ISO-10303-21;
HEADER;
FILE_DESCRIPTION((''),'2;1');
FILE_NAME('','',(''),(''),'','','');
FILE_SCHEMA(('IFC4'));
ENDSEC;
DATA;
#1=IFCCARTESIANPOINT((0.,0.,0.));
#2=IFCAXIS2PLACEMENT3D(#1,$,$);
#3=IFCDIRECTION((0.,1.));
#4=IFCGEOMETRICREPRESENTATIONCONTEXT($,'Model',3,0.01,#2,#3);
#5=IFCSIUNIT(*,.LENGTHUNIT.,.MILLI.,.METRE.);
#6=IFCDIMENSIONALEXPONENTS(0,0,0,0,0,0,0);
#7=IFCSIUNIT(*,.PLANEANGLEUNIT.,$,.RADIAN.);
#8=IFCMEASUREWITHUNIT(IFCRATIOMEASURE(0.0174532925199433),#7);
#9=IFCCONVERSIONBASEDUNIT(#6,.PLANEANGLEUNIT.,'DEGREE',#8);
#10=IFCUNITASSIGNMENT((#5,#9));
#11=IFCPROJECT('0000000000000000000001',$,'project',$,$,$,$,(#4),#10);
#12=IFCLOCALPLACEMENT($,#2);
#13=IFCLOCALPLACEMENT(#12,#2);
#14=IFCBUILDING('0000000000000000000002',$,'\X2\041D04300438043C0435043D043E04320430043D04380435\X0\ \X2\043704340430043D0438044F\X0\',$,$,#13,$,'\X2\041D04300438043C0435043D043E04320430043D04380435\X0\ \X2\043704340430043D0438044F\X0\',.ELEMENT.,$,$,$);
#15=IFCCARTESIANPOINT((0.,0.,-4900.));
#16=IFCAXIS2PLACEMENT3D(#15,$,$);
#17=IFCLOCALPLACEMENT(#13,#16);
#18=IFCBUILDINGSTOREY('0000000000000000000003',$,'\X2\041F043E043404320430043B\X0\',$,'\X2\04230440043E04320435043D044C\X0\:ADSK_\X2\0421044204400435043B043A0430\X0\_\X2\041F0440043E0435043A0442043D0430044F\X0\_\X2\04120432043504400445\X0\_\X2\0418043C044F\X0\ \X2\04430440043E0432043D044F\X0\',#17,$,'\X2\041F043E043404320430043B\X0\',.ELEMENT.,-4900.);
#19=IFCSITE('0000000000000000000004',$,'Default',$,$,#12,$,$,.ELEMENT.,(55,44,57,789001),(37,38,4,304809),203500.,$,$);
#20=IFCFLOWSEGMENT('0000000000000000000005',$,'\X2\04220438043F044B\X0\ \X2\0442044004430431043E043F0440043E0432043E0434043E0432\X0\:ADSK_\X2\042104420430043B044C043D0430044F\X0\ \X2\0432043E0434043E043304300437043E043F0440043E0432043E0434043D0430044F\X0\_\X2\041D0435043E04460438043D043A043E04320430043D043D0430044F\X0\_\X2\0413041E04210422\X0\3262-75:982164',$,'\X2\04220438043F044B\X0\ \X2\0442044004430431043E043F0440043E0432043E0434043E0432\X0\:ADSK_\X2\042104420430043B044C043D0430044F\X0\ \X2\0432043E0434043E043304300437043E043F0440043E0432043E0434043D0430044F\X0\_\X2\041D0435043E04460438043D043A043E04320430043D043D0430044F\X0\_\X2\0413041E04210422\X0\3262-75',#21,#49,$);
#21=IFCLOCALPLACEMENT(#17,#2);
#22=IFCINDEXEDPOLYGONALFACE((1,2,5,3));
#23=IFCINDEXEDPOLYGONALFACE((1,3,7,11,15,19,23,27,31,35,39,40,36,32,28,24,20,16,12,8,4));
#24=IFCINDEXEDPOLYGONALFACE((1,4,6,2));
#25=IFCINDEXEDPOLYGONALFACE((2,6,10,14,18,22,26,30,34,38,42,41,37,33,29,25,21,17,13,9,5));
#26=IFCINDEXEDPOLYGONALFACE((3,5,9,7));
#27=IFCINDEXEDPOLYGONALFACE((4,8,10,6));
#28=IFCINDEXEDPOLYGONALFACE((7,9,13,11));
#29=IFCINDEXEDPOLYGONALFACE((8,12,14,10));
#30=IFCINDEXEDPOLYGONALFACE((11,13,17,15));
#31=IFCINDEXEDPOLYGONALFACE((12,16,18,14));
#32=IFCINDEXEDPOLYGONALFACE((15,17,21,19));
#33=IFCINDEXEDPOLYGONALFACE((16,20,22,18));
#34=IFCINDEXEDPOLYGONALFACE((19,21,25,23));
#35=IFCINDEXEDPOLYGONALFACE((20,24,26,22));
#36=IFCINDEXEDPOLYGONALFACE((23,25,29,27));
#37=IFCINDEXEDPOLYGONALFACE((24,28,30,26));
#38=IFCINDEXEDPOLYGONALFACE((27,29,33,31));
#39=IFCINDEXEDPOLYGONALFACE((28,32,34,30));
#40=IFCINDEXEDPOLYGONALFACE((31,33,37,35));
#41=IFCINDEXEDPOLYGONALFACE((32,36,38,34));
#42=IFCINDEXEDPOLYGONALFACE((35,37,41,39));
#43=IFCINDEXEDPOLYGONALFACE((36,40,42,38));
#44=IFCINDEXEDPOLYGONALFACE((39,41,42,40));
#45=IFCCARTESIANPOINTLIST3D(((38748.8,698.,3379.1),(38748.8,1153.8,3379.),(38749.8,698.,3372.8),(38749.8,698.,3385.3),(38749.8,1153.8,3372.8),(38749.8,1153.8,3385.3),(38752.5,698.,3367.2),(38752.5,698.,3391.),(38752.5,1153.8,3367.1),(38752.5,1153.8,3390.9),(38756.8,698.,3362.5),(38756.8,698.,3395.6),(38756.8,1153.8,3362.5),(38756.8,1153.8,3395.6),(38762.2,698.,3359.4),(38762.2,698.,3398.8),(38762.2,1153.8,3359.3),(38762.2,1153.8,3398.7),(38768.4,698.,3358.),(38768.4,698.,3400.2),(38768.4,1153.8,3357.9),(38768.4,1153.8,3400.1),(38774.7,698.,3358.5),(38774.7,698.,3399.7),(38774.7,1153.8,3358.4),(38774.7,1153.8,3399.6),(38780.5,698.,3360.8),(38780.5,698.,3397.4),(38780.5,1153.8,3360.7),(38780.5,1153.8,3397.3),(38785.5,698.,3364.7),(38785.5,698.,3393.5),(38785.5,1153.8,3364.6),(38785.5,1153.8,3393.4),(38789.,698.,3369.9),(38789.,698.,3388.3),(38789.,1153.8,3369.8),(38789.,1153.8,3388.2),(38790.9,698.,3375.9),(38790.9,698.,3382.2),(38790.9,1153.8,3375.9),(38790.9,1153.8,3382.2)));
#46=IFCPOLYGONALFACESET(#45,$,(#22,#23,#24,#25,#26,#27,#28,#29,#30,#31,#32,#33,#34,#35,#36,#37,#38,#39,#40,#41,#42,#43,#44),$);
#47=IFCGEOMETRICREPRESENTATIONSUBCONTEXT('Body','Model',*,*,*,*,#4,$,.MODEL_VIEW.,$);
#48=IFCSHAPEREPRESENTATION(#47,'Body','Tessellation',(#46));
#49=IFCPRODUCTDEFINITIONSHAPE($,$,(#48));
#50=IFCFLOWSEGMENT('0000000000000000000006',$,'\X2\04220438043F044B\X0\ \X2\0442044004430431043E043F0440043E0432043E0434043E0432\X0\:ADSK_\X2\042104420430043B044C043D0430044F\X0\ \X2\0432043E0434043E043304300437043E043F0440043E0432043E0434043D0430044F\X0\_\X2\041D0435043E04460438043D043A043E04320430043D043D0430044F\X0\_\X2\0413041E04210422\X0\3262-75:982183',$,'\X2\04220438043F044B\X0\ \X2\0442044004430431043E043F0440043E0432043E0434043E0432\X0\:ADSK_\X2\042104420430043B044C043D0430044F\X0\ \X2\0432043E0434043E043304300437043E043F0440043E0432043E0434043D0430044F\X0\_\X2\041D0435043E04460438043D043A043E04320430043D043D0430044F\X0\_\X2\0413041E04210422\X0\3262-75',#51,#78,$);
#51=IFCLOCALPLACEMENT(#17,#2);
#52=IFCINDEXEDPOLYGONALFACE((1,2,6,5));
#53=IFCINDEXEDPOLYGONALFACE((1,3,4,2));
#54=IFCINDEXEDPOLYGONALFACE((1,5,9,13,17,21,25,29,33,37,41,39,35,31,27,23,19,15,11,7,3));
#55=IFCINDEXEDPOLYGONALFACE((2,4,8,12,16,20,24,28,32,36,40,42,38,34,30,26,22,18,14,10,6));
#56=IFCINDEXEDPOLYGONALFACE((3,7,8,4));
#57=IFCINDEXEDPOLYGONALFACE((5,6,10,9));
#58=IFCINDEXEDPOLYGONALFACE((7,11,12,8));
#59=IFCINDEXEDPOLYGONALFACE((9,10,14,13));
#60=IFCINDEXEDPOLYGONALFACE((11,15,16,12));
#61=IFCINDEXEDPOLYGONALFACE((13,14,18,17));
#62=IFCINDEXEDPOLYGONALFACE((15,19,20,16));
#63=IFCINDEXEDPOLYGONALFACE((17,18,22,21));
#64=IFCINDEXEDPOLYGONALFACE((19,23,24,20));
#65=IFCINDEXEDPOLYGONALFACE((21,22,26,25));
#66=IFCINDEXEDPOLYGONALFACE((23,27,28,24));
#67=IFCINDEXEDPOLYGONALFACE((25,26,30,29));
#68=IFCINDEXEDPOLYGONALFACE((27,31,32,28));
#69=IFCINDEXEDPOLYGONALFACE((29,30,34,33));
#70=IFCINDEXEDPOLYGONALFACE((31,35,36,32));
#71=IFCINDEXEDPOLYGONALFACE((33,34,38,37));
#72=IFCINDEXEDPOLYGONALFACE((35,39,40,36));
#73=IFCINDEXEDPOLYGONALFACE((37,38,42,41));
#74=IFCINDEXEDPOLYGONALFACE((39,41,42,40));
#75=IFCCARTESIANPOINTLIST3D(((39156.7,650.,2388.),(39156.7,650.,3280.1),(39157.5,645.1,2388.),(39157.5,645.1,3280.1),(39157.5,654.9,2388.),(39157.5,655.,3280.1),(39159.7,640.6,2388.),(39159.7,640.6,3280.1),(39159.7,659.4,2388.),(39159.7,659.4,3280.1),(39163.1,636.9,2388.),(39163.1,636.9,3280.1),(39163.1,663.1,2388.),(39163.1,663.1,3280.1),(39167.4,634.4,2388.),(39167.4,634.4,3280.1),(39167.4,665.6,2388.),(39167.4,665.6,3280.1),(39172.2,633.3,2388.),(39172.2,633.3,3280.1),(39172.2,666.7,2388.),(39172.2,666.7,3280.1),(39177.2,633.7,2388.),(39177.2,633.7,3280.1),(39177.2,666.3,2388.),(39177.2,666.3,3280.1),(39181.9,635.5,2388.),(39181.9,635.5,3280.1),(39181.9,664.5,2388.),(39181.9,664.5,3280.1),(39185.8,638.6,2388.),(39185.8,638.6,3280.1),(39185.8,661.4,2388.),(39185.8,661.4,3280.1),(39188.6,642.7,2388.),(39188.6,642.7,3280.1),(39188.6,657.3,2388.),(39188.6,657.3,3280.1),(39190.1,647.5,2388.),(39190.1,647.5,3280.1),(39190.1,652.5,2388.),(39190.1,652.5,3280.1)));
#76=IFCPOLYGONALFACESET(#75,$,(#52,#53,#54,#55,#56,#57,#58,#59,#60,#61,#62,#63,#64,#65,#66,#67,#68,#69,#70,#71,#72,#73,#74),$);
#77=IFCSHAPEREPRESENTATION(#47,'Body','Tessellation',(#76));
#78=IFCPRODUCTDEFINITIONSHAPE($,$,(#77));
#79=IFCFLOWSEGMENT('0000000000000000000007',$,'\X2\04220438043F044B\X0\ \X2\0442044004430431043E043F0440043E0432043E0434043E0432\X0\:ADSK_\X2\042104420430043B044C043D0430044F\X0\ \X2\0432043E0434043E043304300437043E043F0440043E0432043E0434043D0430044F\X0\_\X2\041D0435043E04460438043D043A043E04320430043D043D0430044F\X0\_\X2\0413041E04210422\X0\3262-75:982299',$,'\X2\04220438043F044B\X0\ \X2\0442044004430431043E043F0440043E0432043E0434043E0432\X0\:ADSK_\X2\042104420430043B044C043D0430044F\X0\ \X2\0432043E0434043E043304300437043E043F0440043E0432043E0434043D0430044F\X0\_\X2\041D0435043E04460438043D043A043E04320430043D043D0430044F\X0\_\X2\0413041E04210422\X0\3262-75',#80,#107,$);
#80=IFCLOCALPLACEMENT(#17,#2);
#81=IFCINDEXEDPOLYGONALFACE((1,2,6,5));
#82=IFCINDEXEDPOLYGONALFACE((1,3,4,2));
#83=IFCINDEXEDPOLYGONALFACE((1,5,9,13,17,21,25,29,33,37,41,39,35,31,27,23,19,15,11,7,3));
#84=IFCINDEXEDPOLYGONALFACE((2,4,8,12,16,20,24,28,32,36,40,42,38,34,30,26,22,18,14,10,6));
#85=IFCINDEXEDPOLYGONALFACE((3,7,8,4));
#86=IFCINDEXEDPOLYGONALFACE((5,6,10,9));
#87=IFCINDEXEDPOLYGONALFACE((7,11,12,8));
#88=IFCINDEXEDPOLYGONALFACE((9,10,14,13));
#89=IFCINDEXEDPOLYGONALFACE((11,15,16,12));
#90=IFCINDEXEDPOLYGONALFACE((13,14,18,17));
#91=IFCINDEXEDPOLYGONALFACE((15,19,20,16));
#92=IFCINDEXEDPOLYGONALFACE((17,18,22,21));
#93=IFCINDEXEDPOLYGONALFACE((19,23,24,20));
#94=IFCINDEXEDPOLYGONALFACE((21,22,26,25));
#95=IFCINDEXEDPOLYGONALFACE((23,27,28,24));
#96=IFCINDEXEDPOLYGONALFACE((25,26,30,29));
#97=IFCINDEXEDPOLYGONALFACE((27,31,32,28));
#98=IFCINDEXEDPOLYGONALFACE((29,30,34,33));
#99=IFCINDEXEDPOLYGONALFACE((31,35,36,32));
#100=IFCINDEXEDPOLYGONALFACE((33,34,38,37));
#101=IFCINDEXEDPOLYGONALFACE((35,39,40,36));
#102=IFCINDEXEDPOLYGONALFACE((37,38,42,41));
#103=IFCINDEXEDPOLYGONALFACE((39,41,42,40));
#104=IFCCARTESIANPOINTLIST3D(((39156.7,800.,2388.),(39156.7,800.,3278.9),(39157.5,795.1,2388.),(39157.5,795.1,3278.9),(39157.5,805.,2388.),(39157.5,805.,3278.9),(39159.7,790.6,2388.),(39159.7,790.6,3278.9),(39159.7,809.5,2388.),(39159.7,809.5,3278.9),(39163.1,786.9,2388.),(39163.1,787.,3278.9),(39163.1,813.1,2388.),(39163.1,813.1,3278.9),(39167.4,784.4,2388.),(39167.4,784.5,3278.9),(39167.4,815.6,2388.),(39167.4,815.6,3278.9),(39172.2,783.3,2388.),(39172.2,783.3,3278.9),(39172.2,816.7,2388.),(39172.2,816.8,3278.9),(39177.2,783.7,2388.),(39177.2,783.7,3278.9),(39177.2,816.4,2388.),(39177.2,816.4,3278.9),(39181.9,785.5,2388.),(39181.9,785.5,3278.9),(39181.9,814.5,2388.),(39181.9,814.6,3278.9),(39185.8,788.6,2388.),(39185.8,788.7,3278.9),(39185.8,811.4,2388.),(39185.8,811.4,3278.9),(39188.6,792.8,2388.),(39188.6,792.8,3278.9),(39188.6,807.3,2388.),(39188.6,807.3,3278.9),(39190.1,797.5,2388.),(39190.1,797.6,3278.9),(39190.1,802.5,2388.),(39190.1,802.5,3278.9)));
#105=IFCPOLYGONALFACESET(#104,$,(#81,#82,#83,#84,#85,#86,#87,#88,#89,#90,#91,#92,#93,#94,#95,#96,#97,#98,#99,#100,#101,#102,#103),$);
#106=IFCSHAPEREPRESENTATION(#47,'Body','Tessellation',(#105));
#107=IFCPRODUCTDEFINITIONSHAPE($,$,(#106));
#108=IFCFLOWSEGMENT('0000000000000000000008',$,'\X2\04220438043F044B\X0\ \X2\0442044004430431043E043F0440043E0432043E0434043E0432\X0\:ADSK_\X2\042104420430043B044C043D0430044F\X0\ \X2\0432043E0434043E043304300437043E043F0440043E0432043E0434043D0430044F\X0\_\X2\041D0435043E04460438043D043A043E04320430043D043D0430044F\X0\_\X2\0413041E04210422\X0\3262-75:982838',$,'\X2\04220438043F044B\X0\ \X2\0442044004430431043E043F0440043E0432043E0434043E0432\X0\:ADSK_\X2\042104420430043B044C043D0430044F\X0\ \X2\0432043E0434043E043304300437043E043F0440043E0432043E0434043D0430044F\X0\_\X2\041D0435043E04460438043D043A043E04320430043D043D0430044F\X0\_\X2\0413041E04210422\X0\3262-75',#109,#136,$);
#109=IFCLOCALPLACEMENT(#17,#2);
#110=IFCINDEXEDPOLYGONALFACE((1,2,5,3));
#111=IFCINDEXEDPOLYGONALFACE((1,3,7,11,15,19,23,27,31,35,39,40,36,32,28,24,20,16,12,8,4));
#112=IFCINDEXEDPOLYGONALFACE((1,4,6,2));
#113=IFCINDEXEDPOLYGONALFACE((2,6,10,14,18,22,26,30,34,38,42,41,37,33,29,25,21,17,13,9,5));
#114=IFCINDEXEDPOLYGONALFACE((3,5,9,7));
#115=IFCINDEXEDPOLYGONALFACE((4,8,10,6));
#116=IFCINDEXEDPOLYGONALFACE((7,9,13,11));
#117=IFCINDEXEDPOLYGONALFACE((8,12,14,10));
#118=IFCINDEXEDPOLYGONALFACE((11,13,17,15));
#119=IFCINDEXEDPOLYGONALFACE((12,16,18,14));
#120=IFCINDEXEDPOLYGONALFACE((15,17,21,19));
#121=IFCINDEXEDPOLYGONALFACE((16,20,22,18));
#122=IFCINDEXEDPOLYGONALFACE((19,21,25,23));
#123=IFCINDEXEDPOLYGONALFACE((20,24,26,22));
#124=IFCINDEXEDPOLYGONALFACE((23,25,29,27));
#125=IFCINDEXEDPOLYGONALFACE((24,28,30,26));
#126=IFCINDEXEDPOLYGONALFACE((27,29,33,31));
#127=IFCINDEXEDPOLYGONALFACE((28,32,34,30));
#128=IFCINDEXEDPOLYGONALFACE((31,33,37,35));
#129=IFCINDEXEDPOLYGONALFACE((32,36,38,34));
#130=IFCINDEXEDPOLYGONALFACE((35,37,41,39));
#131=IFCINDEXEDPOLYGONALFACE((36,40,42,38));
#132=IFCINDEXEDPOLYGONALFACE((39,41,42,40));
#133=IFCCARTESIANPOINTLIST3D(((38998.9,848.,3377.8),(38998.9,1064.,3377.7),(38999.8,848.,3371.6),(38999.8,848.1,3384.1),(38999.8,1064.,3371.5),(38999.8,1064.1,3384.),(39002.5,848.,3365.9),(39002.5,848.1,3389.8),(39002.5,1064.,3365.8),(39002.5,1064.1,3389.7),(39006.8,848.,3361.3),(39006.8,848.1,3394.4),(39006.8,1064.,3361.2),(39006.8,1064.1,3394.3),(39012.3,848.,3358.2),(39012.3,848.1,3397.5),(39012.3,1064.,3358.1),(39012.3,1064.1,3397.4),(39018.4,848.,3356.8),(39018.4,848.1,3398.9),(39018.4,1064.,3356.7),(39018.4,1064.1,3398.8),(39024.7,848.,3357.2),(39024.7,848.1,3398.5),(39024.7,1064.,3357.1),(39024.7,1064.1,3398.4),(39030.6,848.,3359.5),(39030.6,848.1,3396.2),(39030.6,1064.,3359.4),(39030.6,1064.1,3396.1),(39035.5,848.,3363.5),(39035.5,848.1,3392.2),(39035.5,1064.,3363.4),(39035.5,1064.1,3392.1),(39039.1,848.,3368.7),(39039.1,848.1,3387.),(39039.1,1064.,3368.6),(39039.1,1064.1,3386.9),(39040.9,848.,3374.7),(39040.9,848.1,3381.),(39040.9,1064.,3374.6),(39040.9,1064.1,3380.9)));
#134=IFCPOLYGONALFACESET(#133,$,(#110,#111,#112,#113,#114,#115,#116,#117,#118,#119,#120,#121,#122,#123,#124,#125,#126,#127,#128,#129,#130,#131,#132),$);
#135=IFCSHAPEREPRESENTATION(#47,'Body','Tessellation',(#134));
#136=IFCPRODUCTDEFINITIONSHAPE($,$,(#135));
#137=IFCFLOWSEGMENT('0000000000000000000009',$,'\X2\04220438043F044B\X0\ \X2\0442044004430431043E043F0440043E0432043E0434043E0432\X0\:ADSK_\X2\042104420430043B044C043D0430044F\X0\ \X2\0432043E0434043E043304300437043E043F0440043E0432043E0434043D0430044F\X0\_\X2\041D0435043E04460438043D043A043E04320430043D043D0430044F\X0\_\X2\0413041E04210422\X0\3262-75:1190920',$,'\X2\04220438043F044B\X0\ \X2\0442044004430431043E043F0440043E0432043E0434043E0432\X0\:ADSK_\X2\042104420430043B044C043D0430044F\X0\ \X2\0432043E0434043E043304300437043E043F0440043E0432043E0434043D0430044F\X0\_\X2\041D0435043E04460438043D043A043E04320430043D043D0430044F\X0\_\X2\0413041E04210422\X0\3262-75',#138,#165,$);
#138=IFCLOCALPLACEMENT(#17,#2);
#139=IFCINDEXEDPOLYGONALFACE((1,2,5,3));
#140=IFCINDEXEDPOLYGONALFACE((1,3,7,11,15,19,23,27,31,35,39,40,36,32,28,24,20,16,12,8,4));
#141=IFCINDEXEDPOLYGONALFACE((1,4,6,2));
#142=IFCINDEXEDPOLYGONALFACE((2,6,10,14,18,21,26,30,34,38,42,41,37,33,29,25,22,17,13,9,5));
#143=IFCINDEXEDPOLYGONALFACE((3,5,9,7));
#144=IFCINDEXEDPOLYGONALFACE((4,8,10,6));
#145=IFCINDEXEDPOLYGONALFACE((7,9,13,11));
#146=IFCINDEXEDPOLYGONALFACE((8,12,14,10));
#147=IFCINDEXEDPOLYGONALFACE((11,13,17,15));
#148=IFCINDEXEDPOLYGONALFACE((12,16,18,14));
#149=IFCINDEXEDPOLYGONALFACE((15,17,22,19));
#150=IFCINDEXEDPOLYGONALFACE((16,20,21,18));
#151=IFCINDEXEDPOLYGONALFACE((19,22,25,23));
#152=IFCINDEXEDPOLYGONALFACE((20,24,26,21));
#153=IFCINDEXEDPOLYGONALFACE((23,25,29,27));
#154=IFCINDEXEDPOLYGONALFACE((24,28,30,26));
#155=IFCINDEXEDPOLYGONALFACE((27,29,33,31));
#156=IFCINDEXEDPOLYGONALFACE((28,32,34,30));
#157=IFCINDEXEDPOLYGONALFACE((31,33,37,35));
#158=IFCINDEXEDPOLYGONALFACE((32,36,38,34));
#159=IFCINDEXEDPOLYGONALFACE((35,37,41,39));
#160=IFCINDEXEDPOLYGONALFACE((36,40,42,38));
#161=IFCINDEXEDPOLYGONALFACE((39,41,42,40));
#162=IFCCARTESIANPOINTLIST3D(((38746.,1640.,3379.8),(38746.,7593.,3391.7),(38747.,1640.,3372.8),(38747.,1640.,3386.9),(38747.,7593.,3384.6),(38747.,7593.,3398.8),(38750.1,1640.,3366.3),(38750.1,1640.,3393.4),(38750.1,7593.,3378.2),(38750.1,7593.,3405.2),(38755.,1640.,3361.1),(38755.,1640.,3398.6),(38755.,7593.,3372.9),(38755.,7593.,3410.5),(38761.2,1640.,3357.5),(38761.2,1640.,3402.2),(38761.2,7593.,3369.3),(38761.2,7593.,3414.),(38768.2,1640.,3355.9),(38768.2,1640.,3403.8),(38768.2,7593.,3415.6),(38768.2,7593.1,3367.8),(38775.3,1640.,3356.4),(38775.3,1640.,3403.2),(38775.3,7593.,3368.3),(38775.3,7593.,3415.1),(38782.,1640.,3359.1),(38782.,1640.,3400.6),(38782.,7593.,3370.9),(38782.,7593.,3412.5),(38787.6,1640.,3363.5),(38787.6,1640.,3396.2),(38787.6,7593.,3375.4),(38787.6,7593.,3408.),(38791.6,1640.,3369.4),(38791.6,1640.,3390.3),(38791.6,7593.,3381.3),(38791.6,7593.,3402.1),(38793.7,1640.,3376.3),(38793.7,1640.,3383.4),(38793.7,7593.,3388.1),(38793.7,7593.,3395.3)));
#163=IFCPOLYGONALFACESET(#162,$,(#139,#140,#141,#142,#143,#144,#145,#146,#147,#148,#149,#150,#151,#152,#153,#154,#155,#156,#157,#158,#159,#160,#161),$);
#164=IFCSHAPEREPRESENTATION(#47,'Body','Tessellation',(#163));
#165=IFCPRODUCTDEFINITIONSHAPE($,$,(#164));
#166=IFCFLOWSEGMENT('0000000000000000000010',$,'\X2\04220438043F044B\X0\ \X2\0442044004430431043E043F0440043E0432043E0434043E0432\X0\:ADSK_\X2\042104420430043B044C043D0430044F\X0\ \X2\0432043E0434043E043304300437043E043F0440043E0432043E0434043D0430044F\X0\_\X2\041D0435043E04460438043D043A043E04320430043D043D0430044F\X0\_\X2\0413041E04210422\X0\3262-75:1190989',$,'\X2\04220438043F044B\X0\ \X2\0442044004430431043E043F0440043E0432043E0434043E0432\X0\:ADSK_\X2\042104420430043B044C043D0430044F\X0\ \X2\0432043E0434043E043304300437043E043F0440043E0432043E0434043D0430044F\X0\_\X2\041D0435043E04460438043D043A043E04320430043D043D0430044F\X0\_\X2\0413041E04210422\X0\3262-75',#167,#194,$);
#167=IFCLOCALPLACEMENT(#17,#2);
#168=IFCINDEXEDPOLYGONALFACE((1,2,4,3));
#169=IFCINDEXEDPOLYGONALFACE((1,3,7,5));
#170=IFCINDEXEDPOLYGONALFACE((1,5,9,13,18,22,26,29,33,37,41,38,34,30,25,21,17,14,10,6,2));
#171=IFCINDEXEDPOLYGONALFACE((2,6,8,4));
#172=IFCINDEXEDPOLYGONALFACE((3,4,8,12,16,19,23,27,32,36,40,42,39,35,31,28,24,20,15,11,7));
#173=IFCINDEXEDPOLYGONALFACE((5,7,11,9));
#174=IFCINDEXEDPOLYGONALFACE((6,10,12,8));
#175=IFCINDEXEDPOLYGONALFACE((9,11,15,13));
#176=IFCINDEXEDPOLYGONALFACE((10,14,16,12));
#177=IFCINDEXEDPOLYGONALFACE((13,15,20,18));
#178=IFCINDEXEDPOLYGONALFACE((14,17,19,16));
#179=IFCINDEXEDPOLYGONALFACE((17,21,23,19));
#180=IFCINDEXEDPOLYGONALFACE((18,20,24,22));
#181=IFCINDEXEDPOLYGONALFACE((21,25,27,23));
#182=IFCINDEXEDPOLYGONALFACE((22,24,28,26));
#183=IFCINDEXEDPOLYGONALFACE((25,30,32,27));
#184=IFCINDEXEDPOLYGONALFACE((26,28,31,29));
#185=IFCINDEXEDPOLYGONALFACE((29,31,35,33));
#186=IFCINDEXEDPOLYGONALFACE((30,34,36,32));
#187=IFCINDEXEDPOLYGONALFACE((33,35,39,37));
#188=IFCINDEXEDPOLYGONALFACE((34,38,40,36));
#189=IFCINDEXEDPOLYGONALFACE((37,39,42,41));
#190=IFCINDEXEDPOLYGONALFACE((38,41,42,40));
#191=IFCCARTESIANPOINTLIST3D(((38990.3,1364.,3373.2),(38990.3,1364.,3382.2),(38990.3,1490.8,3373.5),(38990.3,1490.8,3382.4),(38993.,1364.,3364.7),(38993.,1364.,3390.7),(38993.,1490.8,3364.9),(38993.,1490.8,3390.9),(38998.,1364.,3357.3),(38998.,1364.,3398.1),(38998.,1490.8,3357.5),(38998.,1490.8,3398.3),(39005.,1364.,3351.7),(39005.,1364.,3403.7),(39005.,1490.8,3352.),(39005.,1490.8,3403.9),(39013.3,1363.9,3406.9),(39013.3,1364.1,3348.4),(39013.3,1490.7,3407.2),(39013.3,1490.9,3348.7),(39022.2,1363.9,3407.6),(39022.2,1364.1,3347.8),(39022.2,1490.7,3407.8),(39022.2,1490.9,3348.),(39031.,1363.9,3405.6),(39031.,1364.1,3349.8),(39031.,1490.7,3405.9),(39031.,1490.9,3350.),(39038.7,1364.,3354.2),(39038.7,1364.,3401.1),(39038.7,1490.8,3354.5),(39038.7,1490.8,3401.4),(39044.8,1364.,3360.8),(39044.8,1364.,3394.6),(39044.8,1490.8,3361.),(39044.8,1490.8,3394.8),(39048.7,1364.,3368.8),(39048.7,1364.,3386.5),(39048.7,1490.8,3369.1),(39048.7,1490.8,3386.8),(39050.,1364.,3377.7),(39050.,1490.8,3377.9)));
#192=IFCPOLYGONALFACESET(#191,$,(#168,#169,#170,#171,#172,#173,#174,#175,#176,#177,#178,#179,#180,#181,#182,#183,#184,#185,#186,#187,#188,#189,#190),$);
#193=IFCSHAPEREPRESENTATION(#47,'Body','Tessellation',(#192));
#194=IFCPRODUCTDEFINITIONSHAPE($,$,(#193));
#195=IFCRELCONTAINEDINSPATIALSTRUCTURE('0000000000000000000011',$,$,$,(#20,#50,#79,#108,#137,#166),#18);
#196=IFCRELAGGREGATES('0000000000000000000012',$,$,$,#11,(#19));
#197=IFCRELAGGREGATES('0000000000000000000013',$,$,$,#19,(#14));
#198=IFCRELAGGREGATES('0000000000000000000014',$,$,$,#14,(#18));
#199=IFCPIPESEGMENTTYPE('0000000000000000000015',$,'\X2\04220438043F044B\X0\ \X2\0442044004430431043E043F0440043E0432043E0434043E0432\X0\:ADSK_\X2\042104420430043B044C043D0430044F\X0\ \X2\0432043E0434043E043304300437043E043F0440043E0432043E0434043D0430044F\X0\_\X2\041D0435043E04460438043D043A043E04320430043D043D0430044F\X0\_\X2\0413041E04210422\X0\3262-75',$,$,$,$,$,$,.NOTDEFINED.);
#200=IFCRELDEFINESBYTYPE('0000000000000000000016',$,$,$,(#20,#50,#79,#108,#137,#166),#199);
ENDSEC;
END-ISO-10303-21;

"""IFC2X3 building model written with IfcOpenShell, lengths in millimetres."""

from ifc_helpers import new_model, entity, si_unit, converted_unit, direction, frame, origin, origin_2d_with_axis, place, context, subcontext, project, spatial, circle, extrude, type_object, element, save


model = new_model("IFC2X3")

# Units and contexts
model_context = context("Model", 3, precision=0.01, world=origin(), true_north=direction((0.0, 1.0)))
body_context = subcontext(model_context, "Body", "Model", "MODEL_VIEW")
ifc_project = project(units=[si_unit("LENGTHUNIT", "METRE", prefix="MILLI"), converted_unit("PLANEANGLEUNIT", "DEGREE", entity("IfcRatioMeasure", 0.0174532925199433), si_unit("PLANEANGLEUNIT", "RADIAN"), dimensions=[0, 0, 0, 0, 0, 0, 0])], contexts=[model_context])

# Site, building, storey
site_placement = place(None, origin())
site = spatial("IfcSite", under=ifc_project, at=site_placement, Name="Default", CompositionType="ELEMENT", RefLatitude=(55, 44, 57, 789001), RefLongitude=(37, 38, 4, 304809), RefElevation=203500.0)
building_placement = place(site_placement, origin())
building = spatial("IfcBuilding", under=site, at=building_placement, Name="Наименование здания", LongName="Наименование здания", CompositionType="ELEMENT")
storey_placement = place(building_placement, frame((0.0, 0.0, -4900.0)))
storey = spatial("IfcBuildingStorey", under=building, at=storey_placement, Name="Подвал", ObjectType="Уровень:ADSK_Стрелка_Проектная_Вверх_Имя уровня", LongName="Подвал", CompositionType="ELEMENT", Elevation=-4900.0)

# Flow segments
pipe_segment_type = type_object("IfcPipeSegmentType", Name="Типы трубопроводов:ADSK_Стальная водогазопроводная_Неоцинкованная_ГОСТ3262-75", PredefinedType="NOTDEFINED")
flow_segment_1_placement = place(storey_placement, frame((38747.2, 698.0, 3356.3)))
element("IfcFlowSegment", 1, at=flow_segment_1_placement, inside=storey, type_object=pipe_segment_type, Name="Типы трубопроводов:ADSK_Стальная водогазопроводная_Неоцинкованная_ГОСТ3262-75:982164", ObjectType="Типы трубопроводов:ADSK_Стальная водогазопроводная_Неоцинкованная_ГОСТ3262-75", context=body_context, shape_type="SweptSolid", body=[
    extrude(circle(Radius=21.1, at=origin_2d_with_axis()), frame((22.8, 0.0, 22.8), z_axis=(0.0, 1.0, -0.000136), x_axis=(-1.0, 0.0, 0.0)), (0.0, 0.0, 1.0), 455.8),
])
flow_segment_2_placement = place(storey_placement, frame((39155.2, 631.6, 2388.0)))
element("IfcFlowSegment", 2, at=flow_segment_2_placement, inside=storey, type_object=pipe_segment_type, Name="Типы трубопроводов:ADSK_Стальная водогазопроводная_Неоцинкованная_ГОСТ3262-75:982183", ObjectType="Типы трубопроводов:ADSK_Стальная водогазопроводная_Неоцинкованная_ГОСТ3262-75", context=body_context, shape_type="SweptSolid", body=[
    extrude(circle(Radius=16.8, at=origin_2d_with_axis()), frame((18.4, 18.4, 0.0), z_axis=(0.0, 0.000015, 1.0), x_axis=(-1.0, 0.0, 0.0)), (0.0, 0.0, 1.0), 892.1),
])
flow_segment_3_placement = place(storey_placement, frame((39155.2, 781.7, 2388.0)))
element("IfcFlowSegment", 3, at=flow_segment_3_placement, inside=storey, type_object=pipe_segment_type, Name="Типы трубопроводов:ADSK_Стальная водогазопроводная_Неоцинкованная_ГОСТ3262-75:982299", ObjectType="Типы трубопроводов:ADSK_Стальная водогазопроводная_Неоцинкованная_ГОСТ3262-75", context=body_context, shape_type="SweptSolid", body=[
    extrude(circle(Radius=16.8, at=origin_2d_with_axis()), frame((18.4, 18.4, 0.0), z_axis=(0.0, 0.000011, 1.0), x_axis=(-1.0, 0.0, 0.0)), (0.0, 0.0, 1.0), 890.9),
])
flow_segment_4_placement = place(storey_placement, frame((38997.2, 848.0, 3355.0)))
element("IfcFlowSegment", 4, at=flow_segment_4_placement, inside=storey, type_object=pipe_segment_type, Name="Типы трубопроводов:ADSK_Стальная водогазопроводная_Неоцинкованная_ГОСТ3262-75:982838", ObjectType="Типы трубопроводов:ADSK_Стальная водогазопроводная_Неоцинкованная_ГОСТ3262-75", context=body_context, shape_type="SweptSolid", body=[
    extrude(circle(Radius=21.1, at=origin_2d_with_axis()), frame((22.8, 0.0, 22.9), z_axis=(0.0, 1.0, -0.000479), x_axis=(-1.0, 0.0, 0.0)), (0.0, 0.0, 1.0), 216.0),
])
flow_segment_5_placement = place(storey_placement, frame((38744.4, 1640.0, 3354.2)))
element("IfcFlowSegment", 5, at=flow_segment_5_placement, inside=storey, type_object=pipe_segment_type, Name="Типы трубопроводов:ADSK_Стальная водогазопроводная_Неоцинкованная_ГОСТ3262-75:1190920", ObjectType="Типы трубопроводов:ADSK_Стальная водогазопроводная_Неоцинкованная_ГОСТ3262-75", context=body_context, shape_type="SweptSolid", body=[
    extrude(circle(Radius=24.0, at=origin_2d_with_axis()), frame((25.6, 0.1, 25.6), z_axis=(0.0, 0.999998, 0.001991), x_axis=(-1.0, 0.0, 0.0)), (0.0, 0.0, 1.0), 5953.0),
])
flow_segment_6_placement = place(storey_placement, frame((38988.4, 1363.9, 3346.1)))
element("IfcFlowSegment", 6, at=flow_segment_6_placement, inside=storey, type_object=pipe_segment_type, Name="Типы трубопроводов:ADSK_Стальная водогазопроводная_Неоцинкованная_ГОСТ3262-75:1190989", ObjectType="Типы трубопроводов:ADSK_Стальная водогазопроводная_Неоцинкованная_ГОСТ3262-75", context=body_context, shape_type="SweptSolid", body=[
    extrude(circle(Radius=30.0, at=origin_2d_with_axis()), frame((31.6, 0.1, 31.6), z_axis=(0.0, 0.999998, 0.001906), x_axis=(1.0, 0.0, 0.0)), (0.0, 0.0, 1.0), 126.8),
])

save(model, "model.ifc")
